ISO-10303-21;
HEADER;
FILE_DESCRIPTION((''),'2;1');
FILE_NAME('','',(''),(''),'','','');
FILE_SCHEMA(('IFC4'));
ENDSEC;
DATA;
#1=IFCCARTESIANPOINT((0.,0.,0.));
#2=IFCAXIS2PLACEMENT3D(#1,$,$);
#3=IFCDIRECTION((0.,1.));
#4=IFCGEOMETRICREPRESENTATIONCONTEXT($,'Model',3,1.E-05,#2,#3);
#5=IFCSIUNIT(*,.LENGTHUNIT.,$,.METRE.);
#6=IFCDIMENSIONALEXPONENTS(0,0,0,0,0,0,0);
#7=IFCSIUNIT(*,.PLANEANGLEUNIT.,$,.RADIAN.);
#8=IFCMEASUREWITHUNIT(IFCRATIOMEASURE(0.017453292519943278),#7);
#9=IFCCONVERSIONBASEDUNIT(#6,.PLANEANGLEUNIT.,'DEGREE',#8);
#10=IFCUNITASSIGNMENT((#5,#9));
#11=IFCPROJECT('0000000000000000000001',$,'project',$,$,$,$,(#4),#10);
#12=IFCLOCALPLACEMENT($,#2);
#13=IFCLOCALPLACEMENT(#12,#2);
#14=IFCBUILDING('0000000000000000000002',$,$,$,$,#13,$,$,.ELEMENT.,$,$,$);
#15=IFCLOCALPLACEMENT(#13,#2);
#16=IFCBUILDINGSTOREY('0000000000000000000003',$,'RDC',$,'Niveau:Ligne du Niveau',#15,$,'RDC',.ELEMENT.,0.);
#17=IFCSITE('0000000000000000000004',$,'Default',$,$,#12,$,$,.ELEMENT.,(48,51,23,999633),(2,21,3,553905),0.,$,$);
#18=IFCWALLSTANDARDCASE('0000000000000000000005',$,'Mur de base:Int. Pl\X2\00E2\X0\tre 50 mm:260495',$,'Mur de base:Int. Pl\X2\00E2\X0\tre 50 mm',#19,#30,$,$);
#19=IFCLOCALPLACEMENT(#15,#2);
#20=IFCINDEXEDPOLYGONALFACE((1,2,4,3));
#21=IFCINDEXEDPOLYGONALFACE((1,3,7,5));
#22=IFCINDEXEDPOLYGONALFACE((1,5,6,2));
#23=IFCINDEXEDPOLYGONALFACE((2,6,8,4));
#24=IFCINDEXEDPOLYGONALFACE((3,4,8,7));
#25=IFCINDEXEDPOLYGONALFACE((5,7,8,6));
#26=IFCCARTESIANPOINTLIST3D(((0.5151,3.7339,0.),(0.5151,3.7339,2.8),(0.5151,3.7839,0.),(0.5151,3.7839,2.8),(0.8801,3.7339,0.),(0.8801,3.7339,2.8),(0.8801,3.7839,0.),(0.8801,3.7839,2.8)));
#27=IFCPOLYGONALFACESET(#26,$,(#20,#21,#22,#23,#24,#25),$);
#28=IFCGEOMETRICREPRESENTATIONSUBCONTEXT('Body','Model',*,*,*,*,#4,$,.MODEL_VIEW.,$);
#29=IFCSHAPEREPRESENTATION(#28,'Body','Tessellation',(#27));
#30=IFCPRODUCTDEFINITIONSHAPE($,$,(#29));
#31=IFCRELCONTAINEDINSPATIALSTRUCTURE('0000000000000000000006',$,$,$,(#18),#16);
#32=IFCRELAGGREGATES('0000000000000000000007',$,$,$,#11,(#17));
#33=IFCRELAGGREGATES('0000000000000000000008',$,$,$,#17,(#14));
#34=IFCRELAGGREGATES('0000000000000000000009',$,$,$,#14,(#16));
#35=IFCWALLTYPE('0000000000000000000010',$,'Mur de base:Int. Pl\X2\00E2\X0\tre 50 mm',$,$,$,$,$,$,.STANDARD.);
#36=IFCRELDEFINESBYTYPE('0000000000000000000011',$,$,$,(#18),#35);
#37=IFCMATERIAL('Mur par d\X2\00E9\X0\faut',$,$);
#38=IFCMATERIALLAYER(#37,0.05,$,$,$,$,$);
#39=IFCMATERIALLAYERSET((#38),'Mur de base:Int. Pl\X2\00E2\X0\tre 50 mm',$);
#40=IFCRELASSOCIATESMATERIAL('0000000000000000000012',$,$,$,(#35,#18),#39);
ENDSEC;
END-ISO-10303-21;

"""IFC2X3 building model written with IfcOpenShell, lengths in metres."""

from ifc_helpers import new_model, entity, si_unit, converted_unit, direction, frame, frame_2d, origin, place, context, subcontext, project, spatial, rectangle, extrude, material, layer, layer_set, layer_usage, type_object, element, save


model = new_model("IFC2X3")

# Units and contexts
model_context = context("Model", 3, precision=1e-05, world=origin(), true_north=direction((0.0, 1.0)))
body_context = subcontext(model_context, "Body", "Model", "MODEL_VIEW")
ifc_project = project(units=[si_unit("LENGTHUNIT", "METRE"), converted_unit("PLANEANGLEUNIT", "DEGREE", entity("IfcRatioMeasure", 0.017453292519943278), si_unit("PLANEANGLEUNIT", "RADIAN"), dimensions=[0, 0, 0, 0, 0, 0, 0])], contexts=[model_context])

# Site, building, storey
site_placement = place(None, origin())
site = spatial("IfcSite", under=ifc_project, at=site_placement, Name="Default", CompositionType="ELEMENT", RefLatitude=(48, 51, 23, 999633), RefLongitude=(2, 21, 3, 553905), RefElevation=0.0)
building_placement = place(site_placement, origin())
building = spatial("IfcBuilding", under=site, at=building_placement, CompositionType="ELEMENT")
storey_placement = place(building_placement, origin())
storey = spatial("IfcBuildingStorey", under=building, at=storey_placement, Name="RDC", ObjectType="Niveau:Ligne du Niveau", LongName="RDC", CompositionType="ELEMENT", Elevation=0.0)

# Shared definitions
ifc_material_1 = material(Name="Mur par défaut")

# Wall
ifc_layer_1 = layer(ifc_material_1, 0.05)
ifc_layer_set_1 = layer_set([ifc_layer_1], Name="Mur de base:Int. Plâtre 50 mm")
ifc_layer_usage_1 = layer_usage(ifc_layer_set_1, "AXIS2", "NEGATIVE", 0.025)
wall_type_1 = type_object("IfcWallType", Name="Mur de base:Int. Plâtre 50 mm", PredefinedType="STANDARD", material=ifc_layer_set_1)
wall_1_placement = place(storey_placement, frame((0.5151, 3.7589, 0.0)))
element("IfcWallStandardCase", 1, at=wall_1_placement, inside=storey, type_object=wall_type_1, material=ifc_layer_usage_1, Name="Mur de base:Int. Plâtre 50 mm:260495", ObjectType="Mur de base:Int. Plâtre 50 mm", context=body_context, shape_type="SweptSolid", body=[
    extrude(rectangle(XDim=0.365, YDim=0.05, at=frame_2d((0.1825, 0.0), x_axis=(-1.0, 0.0))), origin(), (0.0, 0.0, 1.0), 2.8),
])

save(model, "model.ifc")
